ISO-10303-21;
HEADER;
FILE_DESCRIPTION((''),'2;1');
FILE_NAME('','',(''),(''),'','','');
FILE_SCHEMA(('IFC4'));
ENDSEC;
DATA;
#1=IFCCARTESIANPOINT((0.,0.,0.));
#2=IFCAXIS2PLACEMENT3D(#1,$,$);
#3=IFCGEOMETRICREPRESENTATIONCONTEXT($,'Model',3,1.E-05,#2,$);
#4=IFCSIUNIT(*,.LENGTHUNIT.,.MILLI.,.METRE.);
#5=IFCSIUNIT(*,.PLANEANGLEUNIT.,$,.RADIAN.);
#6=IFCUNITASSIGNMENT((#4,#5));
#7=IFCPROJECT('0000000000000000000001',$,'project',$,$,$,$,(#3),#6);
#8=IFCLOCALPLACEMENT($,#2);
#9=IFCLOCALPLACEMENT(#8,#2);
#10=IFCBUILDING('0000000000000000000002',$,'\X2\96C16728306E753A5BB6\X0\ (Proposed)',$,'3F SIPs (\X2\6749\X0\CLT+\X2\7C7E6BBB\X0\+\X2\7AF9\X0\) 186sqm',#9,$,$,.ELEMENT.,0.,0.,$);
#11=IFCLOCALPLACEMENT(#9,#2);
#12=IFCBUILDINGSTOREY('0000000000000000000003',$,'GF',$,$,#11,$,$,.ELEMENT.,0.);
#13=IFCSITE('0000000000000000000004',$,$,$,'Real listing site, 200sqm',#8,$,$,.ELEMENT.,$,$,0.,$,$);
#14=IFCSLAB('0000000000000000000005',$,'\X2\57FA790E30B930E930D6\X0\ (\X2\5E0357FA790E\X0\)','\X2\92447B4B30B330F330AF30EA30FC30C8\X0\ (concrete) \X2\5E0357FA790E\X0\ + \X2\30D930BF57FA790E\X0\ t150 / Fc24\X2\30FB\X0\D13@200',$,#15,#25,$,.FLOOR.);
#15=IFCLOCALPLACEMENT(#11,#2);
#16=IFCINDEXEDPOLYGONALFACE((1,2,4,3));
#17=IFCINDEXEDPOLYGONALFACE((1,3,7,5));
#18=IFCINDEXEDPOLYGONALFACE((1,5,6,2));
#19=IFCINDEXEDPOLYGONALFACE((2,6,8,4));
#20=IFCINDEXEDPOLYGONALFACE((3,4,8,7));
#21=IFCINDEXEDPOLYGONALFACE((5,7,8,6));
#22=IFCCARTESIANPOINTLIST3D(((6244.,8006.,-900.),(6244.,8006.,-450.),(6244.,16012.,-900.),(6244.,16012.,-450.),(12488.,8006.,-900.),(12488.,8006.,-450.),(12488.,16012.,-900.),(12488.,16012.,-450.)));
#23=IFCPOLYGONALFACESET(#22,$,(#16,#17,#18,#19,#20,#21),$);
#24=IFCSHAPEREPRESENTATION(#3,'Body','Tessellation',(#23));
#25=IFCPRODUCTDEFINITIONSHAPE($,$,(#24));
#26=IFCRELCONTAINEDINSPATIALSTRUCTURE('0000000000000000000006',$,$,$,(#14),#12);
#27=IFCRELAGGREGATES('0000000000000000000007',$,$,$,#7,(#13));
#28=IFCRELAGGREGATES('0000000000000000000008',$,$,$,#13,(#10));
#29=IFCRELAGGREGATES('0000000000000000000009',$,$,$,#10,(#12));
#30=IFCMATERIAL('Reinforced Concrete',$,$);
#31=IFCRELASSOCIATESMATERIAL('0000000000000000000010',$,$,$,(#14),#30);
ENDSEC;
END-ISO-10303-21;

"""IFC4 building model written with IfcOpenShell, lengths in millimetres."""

from ifc_helpers import new_model, si_unit, frame, frame_2d, origin, place, context, project, spatial, rectangle, extrude, material, element, save


model = new_model("IFC4")

# Units and contexts
model_context = context("Model", 3, precision=1e-05, world=origin())
ifc_project = project(units=[si_unit("LENGTHUNIT", "METRE", prefix="MILLI"), si_unit("PLANEANGLEUNIT", "RADIAN")], contexts=[model_context])

# Site, building, storey
site_placement = place(None, origin())
site = spatial("IfcSite", under=ifc_project, at=site_placement, ObjectType="Real listing site, 200sqm", CompositionType="ELEMENT", RefElevation=0.0)
building_placement = place(site_placement, origin())
building = spatial("IfcBuilding", under=site, at=building_placement, Name="雁木の町家 (Proposed)", ObjectType="3F SIPs (杉CLT+籾殻+竹) 186sqm", CompositionType="ELEMENT", ElevationOfRefHeight=0.0, ElevationOfTerrain=0.0)
storey_placement = place(building_placement, origin())
storey = spatial("IfcBuildingStorey", under=building, at=storey_placement, Name="GF", CompositionType="ELEMENT", Elevation=0.0)

# Slab
ifc_material_1 = material(Name="Reinforced Concrete")
slab_1_placement = place(storey_placement, frame((3122.0, 4003.0, -450.0)))
element("IfcSlab", 1, at=slab_1_placement, inside=storey, material=ifc_material_1, Name="基礎スラブ (布基礎)", Description="鉄筋コンクリート (concrete) 布基礎 + ベタ基礎 t150 / Fc24・D13@200", PredefinedType="FLOOR", context=model_context, shape_type="SweptSolid", body=[
    extrude(rectangle(XDim=6244.0, YDim=8006.0, at=frame_2d((3122.0, 4003.0))), frame((3122.0, 4003.0, -450.0)), (0.0, 0.0, 1.0), 450.0),
])

save(model, "model.ifc")
